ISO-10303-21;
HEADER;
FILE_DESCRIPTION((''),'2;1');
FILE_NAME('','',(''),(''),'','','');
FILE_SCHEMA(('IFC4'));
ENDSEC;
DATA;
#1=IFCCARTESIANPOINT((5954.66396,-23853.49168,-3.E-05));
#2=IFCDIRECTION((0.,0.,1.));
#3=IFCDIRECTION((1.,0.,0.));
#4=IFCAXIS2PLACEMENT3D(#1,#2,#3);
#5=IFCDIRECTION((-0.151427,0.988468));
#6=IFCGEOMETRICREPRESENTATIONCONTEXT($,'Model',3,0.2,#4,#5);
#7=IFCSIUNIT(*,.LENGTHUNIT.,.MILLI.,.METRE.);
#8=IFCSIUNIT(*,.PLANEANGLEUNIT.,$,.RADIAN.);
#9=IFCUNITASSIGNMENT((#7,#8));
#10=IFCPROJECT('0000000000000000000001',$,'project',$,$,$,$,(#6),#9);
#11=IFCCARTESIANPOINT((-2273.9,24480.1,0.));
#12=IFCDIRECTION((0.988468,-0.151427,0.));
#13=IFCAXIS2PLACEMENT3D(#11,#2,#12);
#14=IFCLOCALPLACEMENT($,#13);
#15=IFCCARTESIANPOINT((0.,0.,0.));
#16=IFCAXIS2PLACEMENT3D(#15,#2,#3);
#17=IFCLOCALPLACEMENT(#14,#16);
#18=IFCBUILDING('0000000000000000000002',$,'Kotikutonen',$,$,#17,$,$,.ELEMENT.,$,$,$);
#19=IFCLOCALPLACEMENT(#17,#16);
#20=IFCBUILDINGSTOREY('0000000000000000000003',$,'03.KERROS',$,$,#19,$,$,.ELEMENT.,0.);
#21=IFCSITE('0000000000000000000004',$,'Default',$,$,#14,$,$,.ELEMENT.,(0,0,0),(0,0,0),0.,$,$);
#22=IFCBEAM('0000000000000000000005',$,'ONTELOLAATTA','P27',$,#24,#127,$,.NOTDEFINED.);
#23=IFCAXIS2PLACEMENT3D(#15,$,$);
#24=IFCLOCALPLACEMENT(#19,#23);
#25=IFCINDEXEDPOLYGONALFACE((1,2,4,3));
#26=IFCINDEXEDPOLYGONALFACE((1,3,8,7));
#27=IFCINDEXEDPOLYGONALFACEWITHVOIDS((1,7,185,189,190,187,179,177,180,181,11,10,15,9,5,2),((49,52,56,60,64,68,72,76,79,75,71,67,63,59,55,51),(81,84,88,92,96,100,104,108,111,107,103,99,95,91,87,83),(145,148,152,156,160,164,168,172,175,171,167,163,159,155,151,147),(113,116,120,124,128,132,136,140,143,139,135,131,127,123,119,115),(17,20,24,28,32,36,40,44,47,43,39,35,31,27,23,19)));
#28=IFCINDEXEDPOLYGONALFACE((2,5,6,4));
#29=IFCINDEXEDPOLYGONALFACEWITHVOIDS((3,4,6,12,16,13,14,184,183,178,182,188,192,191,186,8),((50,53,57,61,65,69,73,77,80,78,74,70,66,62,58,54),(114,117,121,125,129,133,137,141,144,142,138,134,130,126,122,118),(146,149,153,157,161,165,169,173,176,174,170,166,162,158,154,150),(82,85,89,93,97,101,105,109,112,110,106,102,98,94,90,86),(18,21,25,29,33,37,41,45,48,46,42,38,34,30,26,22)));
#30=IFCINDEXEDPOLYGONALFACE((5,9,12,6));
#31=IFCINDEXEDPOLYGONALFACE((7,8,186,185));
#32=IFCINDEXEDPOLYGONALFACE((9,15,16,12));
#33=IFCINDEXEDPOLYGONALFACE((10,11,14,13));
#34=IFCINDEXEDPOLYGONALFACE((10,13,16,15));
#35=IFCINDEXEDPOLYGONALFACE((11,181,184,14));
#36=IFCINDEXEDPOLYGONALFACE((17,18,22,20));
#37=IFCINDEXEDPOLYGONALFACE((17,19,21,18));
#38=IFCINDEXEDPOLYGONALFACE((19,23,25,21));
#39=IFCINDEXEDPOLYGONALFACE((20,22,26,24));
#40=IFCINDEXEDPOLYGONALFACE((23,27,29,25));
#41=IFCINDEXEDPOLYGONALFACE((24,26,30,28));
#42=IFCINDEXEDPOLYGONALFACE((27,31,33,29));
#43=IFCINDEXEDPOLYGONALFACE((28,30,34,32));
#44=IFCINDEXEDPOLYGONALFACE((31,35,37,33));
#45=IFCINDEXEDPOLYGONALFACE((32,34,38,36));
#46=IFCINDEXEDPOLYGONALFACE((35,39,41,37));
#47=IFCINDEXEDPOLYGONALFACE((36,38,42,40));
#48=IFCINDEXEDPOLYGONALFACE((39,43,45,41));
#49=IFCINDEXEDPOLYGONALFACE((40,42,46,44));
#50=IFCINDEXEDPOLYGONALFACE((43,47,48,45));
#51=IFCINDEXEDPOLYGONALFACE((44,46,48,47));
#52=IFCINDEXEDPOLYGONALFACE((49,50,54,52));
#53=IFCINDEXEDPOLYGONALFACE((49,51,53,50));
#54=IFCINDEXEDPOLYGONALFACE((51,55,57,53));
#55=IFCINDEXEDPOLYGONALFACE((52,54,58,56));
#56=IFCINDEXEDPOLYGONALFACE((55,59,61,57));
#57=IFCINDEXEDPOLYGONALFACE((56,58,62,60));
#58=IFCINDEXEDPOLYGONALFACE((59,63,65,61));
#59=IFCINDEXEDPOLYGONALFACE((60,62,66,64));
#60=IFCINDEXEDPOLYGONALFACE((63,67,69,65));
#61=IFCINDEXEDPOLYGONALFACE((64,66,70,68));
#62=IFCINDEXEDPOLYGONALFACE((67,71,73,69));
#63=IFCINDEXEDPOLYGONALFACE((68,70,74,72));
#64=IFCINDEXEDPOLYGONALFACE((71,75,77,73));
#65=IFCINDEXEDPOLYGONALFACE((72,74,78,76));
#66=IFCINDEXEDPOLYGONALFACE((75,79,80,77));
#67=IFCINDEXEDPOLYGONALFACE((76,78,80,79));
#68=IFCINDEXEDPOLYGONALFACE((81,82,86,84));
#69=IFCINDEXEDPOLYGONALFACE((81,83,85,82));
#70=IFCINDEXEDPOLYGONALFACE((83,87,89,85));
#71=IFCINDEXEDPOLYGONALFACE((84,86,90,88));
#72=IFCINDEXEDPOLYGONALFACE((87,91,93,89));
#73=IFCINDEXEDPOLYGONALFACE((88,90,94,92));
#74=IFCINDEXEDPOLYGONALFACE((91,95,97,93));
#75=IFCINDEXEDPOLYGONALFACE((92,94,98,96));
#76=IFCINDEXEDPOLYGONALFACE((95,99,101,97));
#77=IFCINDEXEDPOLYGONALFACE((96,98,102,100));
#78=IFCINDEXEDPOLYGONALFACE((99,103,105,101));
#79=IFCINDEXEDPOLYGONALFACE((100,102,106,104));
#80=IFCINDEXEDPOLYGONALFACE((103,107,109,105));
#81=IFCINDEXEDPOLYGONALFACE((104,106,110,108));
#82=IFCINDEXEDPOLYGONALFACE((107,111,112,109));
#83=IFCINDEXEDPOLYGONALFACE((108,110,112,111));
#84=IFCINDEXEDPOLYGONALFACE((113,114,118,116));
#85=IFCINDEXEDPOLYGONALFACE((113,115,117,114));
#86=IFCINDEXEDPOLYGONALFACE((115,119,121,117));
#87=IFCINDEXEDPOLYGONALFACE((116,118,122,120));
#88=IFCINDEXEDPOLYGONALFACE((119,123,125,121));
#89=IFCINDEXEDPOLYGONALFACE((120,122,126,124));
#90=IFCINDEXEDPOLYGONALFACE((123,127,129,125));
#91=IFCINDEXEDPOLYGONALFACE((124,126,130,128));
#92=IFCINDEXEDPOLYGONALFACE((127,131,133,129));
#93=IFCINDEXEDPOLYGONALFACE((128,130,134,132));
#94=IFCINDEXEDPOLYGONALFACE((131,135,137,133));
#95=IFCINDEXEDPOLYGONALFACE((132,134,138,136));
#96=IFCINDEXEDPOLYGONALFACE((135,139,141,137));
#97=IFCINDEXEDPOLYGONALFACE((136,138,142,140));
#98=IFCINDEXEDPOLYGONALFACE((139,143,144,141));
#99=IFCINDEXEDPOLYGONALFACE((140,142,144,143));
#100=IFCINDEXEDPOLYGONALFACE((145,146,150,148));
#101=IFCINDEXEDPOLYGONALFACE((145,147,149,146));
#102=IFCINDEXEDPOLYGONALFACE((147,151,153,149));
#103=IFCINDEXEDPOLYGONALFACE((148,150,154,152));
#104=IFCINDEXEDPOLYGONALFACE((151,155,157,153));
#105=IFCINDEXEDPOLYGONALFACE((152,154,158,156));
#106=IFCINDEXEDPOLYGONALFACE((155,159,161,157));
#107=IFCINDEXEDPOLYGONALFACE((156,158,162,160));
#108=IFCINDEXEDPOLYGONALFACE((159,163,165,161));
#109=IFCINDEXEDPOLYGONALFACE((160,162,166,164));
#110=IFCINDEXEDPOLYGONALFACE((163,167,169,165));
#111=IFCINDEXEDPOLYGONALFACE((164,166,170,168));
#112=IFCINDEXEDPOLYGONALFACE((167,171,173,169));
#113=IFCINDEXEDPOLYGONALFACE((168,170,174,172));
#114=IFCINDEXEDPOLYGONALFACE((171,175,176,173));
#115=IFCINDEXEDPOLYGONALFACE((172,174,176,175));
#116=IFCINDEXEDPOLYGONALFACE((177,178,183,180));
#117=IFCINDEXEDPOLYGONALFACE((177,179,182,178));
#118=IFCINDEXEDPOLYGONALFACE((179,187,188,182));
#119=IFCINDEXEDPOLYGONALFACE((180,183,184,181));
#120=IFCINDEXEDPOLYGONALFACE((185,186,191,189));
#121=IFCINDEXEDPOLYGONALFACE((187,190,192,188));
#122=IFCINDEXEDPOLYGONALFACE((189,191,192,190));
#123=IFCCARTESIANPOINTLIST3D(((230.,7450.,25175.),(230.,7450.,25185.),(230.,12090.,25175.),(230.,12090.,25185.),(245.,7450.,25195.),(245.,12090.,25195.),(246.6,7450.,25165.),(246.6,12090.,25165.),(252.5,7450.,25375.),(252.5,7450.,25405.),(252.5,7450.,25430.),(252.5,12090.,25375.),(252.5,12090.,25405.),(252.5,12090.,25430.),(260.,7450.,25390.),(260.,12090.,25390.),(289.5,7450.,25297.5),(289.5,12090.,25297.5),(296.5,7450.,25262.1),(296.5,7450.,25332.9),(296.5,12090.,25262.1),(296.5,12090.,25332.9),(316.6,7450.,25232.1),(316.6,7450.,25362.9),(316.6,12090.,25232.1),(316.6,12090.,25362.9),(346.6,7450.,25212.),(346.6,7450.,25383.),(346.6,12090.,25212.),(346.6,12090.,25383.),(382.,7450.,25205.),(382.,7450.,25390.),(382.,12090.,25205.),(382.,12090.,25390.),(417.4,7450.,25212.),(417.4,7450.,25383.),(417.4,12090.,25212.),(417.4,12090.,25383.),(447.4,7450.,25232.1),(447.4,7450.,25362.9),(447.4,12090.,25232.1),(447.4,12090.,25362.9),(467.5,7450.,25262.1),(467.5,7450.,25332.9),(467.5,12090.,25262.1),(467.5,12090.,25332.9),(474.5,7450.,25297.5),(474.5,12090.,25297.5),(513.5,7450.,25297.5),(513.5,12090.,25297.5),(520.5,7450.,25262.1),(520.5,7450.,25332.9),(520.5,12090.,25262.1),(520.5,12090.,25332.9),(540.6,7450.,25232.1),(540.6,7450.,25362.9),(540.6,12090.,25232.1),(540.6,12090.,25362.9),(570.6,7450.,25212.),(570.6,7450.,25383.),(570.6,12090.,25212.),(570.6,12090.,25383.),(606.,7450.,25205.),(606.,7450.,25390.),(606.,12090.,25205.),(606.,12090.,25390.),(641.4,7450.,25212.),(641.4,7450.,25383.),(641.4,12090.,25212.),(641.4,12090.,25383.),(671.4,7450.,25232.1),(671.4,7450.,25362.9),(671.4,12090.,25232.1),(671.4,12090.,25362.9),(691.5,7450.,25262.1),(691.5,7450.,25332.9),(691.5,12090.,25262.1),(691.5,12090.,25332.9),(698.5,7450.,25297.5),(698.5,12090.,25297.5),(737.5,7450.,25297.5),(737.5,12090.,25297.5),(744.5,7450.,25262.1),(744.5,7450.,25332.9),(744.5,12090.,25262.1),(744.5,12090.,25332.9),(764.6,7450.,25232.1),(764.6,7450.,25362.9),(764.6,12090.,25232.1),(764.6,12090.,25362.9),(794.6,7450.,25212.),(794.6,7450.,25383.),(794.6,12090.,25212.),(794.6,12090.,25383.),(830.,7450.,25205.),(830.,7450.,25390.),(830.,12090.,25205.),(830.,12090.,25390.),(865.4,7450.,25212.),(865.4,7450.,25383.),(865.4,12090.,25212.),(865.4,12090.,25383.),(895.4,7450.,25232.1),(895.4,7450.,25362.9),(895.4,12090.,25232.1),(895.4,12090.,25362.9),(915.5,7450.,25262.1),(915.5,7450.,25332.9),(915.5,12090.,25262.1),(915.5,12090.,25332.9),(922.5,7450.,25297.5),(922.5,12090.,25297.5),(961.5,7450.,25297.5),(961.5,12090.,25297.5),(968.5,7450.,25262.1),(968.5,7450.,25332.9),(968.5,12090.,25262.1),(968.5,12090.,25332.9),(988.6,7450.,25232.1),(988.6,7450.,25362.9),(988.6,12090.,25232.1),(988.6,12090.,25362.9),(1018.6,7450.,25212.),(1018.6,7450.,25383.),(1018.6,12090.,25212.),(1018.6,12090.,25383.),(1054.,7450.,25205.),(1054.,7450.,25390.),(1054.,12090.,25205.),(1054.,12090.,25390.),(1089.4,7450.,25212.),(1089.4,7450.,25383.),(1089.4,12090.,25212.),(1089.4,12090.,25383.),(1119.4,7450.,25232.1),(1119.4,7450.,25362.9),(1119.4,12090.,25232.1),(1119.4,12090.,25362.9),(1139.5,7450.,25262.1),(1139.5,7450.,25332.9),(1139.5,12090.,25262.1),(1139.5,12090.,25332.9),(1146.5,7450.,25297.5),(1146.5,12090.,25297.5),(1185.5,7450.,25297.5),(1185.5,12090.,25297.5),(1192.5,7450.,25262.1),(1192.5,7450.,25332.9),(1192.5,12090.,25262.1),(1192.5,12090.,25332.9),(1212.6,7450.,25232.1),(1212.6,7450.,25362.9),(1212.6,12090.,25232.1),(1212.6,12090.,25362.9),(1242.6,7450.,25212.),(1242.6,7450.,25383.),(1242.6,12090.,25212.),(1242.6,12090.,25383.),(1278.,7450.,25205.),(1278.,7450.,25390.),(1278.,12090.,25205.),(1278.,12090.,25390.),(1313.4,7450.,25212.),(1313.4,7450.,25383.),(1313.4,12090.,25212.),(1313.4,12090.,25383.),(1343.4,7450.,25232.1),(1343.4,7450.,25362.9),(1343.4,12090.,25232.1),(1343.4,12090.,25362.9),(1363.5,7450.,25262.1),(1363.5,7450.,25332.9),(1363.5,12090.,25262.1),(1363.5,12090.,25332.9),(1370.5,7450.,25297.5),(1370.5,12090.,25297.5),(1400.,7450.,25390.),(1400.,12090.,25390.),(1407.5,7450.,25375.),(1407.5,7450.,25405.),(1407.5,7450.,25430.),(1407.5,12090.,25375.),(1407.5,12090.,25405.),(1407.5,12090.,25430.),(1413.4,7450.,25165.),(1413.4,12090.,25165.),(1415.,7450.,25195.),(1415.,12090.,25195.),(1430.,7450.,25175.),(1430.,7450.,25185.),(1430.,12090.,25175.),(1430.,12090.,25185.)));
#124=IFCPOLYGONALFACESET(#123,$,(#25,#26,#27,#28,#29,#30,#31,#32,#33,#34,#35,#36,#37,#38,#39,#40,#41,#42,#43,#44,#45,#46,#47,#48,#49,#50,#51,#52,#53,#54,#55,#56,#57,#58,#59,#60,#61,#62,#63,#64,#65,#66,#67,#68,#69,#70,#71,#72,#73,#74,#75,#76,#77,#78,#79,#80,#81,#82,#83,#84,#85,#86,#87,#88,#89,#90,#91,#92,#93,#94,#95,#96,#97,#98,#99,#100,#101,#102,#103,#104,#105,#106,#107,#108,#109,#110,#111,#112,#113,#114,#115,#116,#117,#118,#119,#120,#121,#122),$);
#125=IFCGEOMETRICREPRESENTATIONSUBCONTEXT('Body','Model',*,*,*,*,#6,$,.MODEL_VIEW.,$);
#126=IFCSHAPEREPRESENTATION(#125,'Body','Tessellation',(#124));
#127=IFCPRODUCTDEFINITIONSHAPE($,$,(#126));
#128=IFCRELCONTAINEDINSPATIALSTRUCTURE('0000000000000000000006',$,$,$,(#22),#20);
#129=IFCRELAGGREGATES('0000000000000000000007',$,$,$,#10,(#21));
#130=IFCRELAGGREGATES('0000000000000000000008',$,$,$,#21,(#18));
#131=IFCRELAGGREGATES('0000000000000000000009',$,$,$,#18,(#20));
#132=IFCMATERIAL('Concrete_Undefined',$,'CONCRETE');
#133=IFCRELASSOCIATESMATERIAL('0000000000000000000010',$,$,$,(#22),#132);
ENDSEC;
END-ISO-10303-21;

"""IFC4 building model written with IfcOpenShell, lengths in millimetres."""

from ifc_helpers import new_model, si_unit, direction, frame, origin_with_axes, place, context, subcontext, project, spatial, line, indexed_curve, outline, extrude, material, element, save


model = new_model("IFC4")

# Units and contexts
model_context = context("Model", 3, precision=0.2, world=frame((5954.66396, -23853.49168, -3e-05), z_axis=(0.0, 0.0, 1.0), x_axis=(1.0, 0.0, 0.0)), true_north=direction((-0.151427, 0.988468)))
body_context = subcontext(model_context, "Body", "Model", "MODEL_VIEW")
ifc_project = project(units=[si_unit("LENGTHUNIT", "METRE", prefix="MILLI"), si_unit("PLANEANGLEUNIT", "RADIAN")], contexts=[model_context])

# Site, building, storey
site_placement = place(None, frame((-2273.9, 24480.1, 0.0), z_axis=(0.0, 0.0, 1.0), x_axis=(0.988468, -0.151427, 0.0)))
site = spatial("IfcSite", under=ifc_project, at=site_placement, Name="Default", CompositionType="ELEMENT", RefLatitude=(0, 0, 0), RefLongitude=(0, 0, 0), RefElevation=0.0)
building_placement = place(site_placement, origin_with_axes())
building = spatial("IfcBuilding", under=site, at=building_placement, Name="Kotikutonen", CompositionType="ELEMENT")
storey_placement = place(building_placement, origin_with_axes())
storey = spatial("IfcBuildingStorey", under=building, at=storey_placement, Name="03.KERROS", CompositionType="ELEMENT", Elevation=0.0)

# Shared definitions
ifc_material_1 = material(Name="Concrete_Undefined", Category="CONCRETE")

# Beam
beam_1_placement = place(storey_placement, frame((830.0, 12090.0, 25297.5), z_axis=(-1.0, 0.0, 0.0), x_axis=(0.0, -1.0, 0.0)))
element("IfcBeam", 1, at=beam_1_placement, inside=storey, material=ifc_material_1, Name="ONTELOLAATTA", Description="P27", PredefinedType="NOTDEFINED", context=body_context, shape_type="SolidModel", body=[
    extrude(outline(indexed_curve([(-600.0, -122.5), (-583.4, -132.5), (583.4, -132.5), (600.0, -122.5), (600.0, -112.5), (585.0, -102.5), (577.5, 77.5), (570.0, 92.5), (577.5, 107.5), (577.5, 132.5), (-577.5, 132.5), (-577.5, 107.5), (-570.0, 92.5), (-577.5, 77.5), (-585.0, -102.5), (-600.0, -112.5)], segments=[line(1, 2, 3, 4, 5, 6, 7, 8, 9, 10, 11, 12, 13, 14, 15, 16, 1)]), holes=[indexed_curve([(-448.0, -92.5), (-483.4, -85.5), (-513.4, -65.4), (-533.5, -35.4), (-540.5, 0.0), (-533.5, 35.4), (-513.4, 65.4), (-483.4, 85.5), (-448.0, 92.5), (-412.6, 85.5), (-382.6, 65.4), (-362.5, 35.4), (-355.5, 0.0), (-362.5, -35.4), (-382.6, -65.4), (-412.6, -85.5)], segments=[line(1, 2, 3, 4, 5, 6, 7, 8, 9, 10, 11, 12, 13, 14, 15, 16, 1)]), indexed_curve([(-224.0, -92.5), (-259.4, -85.5), (-289.4, -65.4), (-309.5, -35.4), (-316.5, 0.0), (-309.5, 35.4), (-289.4, 65.4), (-259.4, 85.5), (-224.0, 92.5), (-188.6, 85.5), (-158.6, 65.4), (-138.5, 35.4), (-131.5, 0.0), (-138.5, -35.4), (-158.6, -65.4), (-188.6, -85.5)], segments=[line(1, 2, 3, 4, 5, 6, 7, 8, 9, 10, 11, 12, 13, 14, 15, 16, 1)]), indexed_curve([(0.0, -92.5), (-35.4, -85.5), (-65.4, -65.4), (-85.5, -35.4), (-92.5, 0.0), (-85.5, 35.4), (-65.4, 65.4), (-35.4, 85.5), (0.0, 92.5), (35.4, 85.5), (65.4, 65.4), (85.5, 35.4), (92.5, 0.0), (85.5, -35.4), (65.4, -65.4), (35.4, -85.5)], segments=[line(1, 2, 3, 4, 5, 6, 7, 8, 9, 10, 11, 12, 13, 14, 15, 16, 1)]), indexed_curve([(224.0, -92.5), (188.6, -85.5), (158.6, -65.4), (138.5, -35.4), (131.5, 0.0), (138.5, 35.4), (158.6, 65.4), (188.6, 85.5), (224.0, 92.5), (259.4, 85.5), (289.4, 65.4), (309.5, 35.4), (316.5, 0.0), (309.5, -35.4), (289.4, -65.4), (259.4, -85.5)], segments=[line(1, 2, 3, 4, 5, 6, 7, 8, 9, 10, 11, 12, 13, 14, 15, 16, 1)]), indexed_curve([(448.0, -92.5), (412.6, -85.5), (382.6, -65.4), (362.5, -35.4), (355.5, 0.0), (362.5, 35.4), (382.6, 65.4), (412.6, 85.5), (448.0, 92.5), (483.4, 85.5), (513.4, 65.4), (533.5, 35.4), (540.5, 0.0), (533.5, -35.4), (513.4, -65.4), (483.4, -85.5)], segments=[line(1, 2, 3, 4, 5, 6, 7, 8, 9, 10, 11, 12, 13, 14, 15, 16, 1)])]), frame((0.0, 0.0, 0.0), z_axis=(-1.0, 0.0, 0.0), x_axis=(0.0, 0.0, 1.0)), (0.0, 0.0, -1.0), 4640.0),
])

save(model, "model.ifc")
